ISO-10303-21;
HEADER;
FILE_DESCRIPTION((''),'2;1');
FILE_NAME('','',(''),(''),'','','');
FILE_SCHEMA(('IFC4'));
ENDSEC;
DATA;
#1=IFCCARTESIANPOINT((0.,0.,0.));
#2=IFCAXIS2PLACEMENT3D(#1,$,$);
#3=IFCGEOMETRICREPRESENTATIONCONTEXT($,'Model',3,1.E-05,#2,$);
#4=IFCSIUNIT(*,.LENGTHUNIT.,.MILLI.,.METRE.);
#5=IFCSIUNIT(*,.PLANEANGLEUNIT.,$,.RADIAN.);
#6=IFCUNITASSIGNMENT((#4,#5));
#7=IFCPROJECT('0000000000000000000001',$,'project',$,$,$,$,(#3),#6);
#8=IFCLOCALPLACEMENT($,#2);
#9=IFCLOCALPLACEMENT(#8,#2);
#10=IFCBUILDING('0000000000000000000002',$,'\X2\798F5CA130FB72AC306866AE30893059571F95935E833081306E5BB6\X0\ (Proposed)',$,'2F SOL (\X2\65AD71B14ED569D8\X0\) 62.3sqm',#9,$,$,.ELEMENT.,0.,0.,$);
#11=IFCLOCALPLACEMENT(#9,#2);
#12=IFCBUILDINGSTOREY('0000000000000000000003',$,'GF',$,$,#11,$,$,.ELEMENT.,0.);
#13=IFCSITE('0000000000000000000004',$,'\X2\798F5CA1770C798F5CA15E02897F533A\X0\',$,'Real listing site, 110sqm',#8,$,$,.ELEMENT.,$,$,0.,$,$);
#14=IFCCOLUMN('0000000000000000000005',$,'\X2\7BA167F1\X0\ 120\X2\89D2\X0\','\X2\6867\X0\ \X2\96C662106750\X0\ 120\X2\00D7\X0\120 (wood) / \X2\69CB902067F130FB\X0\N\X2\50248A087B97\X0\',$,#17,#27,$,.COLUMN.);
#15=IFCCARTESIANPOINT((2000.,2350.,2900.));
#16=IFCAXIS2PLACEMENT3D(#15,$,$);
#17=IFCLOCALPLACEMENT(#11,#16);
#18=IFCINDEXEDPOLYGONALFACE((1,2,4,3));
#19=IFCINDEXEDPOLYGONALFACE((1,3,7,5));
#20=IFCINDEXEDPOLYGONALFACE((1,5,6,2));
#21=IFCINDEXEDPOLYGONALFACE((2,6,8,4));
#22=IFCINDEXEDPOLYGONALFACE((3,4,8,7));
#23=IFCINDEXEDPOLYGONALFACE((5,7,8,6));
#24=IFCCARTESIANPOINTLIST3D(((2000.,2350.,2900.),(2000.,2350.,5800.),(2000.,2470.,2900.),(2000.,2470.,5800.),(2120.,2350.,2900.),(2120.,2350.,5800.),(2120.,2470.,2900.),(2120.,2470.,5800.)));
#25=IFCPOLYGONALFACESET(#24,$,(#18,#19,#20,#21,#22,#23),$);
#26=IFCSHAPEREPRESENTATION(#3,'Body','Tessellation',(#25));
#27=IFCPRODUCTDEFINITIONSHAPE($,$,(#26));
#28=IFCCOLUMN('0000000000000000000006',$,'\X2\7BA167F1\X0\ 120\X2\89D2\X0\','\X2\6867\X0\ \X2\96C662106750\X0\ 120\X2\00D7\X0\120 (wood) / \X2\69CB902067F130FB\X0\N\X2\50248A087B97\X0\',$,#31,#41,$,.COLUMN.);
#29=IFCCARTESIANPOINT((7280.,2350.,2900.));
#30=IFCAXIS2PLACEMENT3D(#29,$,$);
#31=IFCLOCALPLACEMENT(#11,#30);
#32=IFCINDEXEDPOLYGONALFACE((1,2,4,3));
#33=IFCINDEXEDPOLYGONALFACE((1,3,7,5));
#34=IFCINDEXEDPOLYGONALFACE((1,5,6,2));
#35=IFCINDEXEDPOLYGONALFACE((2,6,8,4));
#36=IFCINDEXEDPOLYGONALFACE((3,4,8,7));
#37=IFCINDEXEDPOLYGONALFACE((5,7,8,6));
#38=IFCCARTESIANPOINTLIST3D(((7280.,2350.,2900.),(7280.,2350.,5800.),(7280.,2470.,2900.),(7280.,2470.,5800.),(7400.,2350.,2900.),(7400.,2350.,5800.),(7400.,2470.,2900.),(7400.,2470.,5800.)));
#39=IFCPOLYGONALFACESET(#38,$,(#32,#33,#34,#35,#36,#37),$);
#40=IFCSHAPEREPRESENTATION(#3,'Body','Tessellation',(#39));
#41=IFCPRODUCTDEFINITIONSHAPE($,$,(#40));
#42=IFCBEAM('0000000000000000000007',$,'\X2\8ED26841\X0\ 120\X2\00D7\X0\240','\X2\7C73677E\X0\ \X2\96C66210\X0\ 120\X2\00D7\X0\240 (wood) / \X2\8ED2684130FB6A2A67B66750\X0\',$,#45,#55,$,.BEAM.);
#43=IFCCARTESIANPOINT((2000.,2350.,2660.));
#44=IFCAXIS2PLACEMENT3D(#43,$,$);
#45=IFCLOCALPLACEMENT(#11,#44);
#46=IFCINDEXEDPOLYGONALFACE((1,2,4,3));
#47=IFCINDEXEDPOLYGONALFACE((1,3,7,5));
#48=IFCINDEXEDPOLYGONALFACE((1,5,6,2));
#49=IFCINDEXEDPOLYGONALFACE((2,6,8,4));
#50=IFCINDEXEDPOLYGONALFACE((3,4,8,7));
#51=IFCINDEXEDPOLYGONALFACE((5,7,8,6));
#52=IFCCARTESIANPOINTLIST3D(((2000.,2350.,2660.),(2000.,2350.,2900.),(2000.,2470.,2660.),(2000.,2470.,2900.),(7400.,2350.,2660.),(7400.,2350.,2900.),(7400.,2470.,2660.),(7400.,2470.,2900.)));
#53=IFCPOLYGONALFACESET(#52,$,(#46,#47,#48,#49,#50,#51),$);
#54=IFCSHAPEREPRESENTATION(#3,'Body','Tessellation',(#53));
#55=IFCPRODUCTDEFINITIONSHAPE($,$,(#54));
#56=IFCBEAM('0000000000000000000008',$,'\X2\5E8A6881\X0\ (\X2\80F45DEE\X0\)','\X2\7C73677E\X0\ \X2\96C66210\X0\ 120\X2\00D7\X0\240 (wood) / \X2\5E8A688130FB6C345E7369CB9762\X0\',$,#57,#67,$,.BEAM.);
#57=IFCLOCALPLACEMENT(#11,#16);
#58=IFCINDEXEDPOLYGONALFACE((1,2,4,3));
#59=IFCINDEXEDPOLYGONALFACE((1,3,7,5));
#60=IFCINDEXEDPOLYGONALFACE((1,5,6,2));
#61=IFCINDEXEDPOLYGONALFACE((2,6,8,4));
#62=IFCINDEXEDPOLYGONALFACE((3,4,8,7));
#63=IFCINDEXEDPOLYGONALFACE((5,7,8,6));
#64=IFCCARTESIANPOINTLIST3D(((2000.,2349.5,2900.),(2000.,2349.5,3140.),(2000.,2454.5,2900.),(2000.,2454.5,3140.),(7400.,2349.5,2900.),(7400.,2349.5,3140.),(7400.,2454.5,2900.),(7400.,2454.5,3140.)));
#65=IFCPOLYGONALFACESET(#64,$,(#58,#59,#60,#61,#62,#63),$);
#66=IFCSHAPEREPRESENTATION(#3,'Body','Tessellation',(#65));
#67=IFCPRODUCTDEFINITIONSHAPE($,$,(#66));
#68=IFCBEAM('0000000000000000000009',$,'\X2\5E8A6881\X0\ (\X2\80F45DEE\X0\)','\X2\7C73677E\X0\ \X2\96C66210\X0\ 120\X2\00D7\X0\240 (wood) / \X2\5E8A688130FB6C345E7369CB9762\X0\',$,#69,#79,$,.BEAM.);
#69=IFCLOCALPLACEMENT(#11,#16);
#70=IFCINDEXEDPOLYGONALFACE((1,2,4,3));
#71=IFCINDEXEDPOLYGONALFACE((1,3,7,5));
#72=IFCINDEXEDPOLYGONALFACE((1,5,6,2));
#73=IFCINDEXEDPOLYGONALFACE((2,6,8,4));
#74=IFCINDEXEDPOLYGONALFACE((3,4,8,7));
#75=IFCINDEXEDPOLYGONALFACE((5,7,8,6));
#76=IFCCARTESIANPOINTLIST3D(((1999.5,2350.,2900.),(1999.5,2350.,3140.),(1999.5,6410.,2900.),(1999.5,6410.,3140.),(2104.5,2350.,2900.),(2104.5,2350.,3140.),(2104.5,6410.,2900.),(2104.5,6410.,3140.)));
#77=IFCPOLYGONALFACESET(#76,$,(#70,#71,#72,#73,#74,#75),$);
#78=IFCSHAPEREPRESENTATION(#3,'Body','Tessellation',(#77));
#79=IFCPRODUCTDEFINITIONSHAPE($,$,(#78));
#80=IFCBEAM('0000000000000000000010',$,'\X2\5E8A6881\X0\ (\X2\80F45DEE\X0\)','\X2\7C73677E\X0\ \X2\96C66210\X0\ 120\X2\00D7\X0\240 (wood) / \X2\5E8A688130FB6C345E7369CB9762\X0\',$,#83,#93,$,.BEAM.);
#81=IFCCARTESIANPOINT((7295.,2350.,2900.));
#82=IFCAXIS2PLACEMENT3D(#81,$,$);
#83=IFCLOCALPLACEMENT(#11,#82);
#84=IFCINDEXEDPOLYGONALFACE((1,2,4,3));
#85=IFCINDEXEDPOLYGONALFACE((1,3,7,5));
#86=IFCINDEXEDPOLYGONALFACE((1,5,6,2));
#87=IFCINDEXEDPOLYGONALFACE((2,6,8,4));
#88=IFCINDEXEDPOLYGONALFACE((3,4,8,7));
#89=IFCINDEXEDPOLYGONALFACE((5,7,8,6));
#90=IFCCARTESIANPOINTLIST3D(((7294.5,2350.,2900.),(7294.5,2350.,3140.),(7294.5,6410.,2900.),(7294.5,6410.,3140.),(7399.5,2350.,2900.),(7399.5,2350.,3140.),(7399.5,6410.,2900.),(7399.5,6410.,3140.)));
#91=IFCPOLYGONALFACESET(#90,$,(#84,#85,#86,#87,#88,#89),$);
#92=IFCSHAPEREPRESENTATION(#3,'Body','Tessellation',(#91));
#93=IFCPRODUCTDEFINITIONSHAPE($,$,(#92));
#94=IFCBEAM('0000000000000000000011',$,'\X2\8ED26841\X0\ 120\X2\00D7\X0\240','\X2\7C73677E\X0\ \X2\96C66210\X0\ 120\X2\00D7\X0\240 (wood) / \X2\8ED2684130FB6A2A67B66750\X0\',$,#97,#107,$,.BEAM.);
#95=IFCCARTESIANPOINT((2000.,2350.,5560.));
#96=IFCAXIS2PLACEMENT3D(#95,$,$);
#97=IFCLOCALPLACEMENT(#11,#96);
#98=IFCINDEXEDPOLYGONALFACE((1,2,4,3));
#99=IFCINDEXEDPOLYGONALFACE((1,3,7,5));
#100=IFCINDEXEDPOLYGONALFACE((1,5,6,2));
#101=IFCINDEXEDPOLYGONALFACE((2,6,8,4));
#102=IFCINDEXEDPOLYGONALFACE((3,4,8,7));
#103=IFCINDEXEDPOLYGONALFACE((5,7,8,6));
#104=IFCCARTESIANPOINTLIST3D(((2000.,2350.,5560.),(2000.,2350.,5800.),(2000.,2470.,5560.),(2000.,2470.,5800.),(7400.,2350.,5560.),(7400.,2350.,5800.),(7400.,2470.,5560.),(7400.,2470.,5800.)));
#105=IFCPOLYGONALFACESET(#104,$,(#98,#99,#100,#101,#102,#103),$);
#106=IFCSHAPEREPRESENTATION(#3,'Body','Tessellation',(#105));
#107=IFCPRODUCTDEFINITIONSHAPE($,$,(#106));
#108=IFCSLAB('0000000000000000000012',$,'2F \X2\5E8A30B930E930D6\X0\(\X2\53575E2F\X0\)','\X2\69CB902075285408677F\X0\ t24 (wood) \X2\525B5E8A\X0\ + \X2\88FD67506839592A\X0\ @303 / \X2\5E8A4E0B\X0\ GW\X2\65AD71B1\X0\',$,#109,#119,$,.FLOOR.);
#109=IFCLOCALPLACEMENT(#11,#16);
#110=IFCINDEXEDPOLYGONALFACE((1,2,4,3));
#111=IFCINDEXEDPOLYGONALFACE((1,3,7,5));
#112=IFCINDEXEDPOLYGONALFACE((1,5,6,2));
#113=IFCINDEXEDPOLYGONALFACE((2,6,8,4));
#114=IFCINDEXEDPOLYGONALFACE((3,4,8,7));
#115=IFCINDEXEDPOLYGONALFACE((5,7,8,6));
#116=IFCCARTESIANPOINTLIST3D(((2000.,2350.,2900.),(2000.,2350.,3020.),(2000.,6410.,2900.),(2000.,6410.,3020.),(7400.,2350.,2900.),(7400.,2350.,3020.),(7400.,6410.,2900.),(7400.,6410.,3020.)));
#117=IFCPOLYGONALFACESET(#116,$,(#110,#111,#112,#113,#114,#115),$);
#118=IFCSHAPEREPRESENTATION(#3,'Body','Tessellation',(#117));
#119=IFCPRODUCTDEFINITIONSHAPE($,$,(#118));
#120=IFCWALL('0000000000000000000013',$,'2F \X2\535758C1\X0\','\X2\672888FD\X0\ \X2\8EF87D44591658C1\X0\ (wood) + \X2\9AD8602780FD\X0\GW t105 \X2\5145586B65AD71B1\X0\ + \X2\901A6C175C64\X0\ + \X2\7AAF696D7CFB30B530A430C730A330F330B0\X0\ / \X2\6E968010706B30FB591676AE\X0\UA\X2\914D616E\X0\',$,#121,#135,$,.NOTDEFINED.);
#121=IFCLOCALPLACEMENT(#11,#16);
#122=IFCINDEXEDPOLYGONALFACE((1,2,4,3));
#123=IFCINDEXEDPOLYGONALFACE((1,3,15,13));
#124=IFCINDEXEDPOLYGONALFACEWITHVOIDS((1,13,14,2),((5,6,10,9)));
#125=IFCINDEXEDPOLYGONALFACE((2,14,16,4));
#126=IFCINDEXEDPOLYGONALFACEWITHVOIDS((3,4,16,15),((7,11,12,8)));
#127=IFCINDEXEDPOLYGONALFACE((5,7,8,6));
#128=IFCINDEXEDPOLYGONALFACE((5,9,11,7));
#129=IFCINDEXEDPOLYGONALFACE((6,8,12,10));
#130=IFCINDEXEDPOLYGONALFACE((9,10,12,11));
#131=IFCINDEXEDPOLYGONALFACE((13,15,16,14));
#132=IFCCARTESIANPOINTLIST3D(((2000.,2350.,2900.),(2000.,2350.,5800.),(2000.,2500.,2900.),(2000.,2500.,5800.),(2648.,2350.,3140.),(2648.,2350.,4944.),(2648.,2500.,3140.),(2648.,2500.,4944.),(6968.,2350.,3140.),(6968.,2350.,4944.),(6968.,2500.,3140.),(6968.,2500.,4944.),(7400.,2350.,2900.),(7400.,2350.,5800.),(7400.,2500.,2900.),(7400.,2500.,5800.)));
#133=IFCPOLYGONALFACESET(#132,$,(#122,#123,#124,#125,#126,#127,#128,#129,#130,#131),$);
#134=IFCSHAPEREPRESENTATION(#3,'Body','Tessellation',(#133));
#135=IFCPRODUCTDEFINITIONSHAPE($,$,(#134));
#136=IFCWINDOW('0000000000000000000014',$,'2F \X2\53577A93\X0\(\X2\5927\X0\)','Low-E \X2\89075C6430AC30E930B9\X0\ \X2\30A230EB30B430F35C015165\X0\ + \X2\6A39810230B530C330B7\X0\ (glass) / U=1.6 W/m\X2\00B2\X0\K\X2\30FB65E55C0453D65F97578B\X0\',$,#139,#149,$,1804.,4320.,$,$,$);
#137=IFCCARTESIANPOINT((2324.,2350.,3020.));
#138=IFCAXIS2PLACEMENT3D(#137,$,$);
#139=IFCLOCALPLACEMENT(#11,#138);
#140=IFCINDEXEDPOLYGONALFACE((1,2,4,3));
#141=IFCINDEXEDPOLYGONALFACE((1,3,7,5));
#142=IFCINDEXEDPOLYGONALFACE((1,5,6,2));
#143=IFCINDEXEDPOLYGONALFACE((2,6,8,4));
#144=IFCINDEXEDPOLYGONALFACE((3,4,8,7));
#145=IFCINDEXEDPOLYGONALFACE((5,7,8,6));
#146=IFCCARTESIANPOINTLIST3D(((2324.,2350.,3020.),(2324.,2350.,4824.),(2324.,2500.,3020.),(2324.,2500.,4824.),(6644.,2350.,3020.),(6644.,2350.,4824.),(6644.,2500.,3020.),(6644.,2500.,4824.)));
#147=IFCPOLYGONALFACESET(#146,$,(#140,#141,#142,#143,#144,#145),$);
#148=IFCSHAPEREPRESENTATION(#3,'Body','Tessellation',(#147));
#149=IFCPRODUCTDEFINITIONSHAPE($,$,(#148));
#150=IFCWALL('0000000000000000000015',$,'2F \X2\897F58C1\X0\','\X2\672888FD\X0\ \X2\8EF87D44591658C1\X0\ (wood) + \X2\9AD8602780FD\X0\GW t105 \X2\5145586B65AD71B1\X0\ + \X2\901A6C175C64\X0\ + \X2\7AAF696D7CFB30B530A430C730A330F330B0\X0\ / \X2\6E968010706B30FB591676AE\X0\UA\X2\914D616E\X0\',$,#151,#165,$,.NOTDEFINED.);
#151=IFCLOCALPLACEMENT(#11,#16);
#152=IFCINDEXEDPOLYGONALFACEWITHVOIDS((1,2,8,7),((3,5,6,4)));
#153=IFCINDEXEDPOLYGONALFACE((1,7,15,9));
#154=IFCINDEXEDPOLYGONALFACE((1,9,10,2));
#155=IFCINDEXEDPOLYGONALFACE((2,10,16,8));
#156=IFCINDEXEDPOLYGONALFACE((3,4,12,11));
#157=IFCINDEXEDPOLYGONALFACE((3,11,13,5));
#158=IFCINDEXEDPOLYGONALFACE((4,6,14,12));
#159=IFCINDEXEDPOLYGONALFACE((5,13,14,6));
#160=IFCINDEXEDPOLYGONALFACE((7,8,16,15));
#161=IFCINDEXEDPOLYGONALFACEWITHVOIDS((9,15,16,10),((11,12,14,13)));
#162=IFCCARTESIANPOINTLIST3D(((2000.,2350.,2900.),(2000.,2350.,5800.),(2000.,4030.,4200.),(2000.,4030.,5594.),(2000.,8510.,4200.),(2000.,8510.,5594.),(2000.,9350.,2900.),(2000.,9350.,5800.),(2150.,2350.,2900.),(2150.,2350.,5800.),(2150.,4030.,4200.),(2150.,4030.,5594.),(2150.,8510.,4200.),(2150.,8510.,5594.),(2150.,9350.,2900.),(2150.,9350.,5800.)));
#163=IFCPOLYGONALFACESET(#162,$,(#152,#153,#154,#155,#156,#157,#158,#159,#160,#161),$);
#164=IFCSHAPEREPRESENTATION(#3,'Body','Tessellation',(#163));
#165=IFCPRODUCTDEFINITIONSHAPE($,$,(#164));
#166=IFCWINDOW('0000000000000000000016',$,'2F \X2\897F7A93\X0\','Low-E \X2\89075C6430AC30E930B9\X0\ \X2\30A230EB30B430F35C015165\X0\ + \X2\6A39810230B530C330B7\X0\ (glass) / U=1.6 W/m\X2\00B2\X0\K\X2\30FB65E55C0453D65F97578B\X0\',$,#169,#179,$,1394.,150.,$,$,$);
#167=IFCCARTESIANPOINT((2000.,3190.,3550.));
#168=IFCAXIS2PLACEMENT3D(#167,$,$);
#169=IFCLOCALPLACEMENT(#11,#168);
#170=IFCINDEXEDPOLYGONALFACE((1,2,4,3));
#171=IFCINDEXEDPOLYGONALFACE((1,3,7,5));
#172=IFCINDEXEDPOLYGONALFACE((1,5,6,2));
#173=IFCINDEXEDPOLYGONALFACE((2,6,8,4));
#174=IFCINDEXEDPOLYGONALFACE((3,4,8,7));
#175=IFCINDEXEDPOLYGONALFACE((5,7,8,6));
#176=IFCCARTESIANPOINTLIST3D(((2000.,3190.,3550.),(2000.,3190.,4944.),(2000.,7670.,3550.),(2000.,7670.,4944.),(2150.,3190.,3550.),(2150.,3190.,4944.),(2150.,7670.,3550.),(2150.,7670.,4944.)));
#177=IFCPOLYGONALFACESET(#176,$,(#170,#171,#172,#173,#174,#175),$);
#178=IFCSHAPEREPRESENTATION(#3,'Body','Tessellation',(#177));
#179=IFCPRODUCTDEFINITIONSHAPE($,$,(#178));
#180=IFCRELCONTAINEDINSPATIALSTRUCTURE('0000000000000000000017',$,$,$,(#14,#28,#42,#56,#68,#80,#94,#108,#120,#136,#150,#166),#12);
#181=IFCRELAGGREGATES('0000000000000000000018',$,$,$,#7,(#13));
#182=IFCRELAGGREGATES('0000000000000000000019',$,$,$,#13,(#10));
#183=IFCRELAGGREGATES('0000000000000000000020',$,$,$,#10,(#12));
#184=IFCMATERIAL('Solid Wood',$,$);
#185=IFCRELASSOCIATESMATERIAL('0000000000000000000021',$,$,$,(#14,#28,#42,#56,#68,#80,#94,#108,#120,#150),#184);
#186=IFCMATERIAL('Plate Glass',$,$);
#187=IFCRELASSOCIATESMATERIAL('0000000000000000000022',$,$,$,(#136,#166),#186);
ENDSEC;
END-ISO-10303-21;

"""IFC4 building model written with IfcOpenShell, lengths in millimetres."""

from ifc_helpers import new_model, si_unit, frame, frame_2d, origin, place, context, project, spatial, rectangle, extrude, material, element, fill, save


model = new_model("IFC4")

# Units and contexts
model_context = context("Model", 3, precision=1e-05, world=origin())
ifc_project = project(units=[si_unit("LENGTHUNIT", "METRE", prefix="MILLI"), si_unit("PLANEANGLEUNIT", "RADIAN")], contexts=[model_context])

# Site, building, storey
site_placement = place(None, origin())
site = spatial("IfcSite", under=ifc_project, at=site_placement, Name="福岡県福岡市西区", ObjectType="Real listing site, 110sqm", CompositionType="ELEMENT", RefElevation=0.0)
building_placement = place(site_placement, origin())
building = spatial("IfcBuilding", under=site, at=building_placement, Name="福岡・犬と暮らす土間広めの家 (Proposed)", ObjectType="2F SOL (断熱仕様) 62.3sqm", CompositionType="ELEMENT", ElevationOfRefHeight=0.0, ElevationOfTerrain=0.0)
storey_placement = place(building_placement, origin())
storey = spatial("IfcBuildingStorey", under=building, at=storey_placement, Name="GF", CompositionType="ELEMENT", Elevation=0.0)

# Columns
ifc_material_1 = material(Name="Solid Wood")
column_1_placement = place(storey_placement, frame((2000.0, 2350.0, 2900.0)))
element("IfcColumn", 1, at=column_1_placement, inside=storey, material=ifc_material_1, Name="管柱 120角", Description="桧 集成材 120×120 (wood) / 構造柱・N値計算", PredefinedType="COLUMN", context=model_context, shape_type="SweptSolid", body=[
    extrude(rectangle(XDim=120.0, YDim=120.0, at=frame_2d((60.0, 60.0))), frame((2000.0, 2350.0, 2900.0)), (0.0, 0.0, 1.0), 2900.0),
])
column_2_placement = place(storey_placement, frame((7280.0, 2350.0, 2900.0)))
element("IfcColumn", 2, at=column_2_placement, inside=storey, material=ifc_material_1, Name="管柱 120角", Description="桧 集成材 120×120 (wood) / 構造柱・N値計算", PredefinedType="COLUMN", context=model_context, shape_type="SweptSolid", body=[
    extrude(rectangle(XDim=120.0, YDim=120.0, at=frame_2d((60.0, 60.0))), frame((7280.0, 2350.0, 2900.0)), (0.0, 0.0, 1.0), 2900.0),
])

# Beams
beam_1_placement = place(storey_placement, frame((2000.0, 2350.0, 2660.0)))
element("IfcBeam", 3, at=beam_1_placement, inside=storey, material=ifc_material_1, Name="軒桁 120×240", Description="米松 集成 120×240 (wood) / 軒桁・横架材", PredefinedType="BEAM", context=model_context, shape_type="SweptSolid", body=[
    extrude(rectangle(XDim=5400.0, YDim=120.0, at=frame_2d((2700.0, 60.0))), frame((2000.0, 2350.0, 2660.0)), (0.0, 0.0, 1.0), 240.0),
])
beam_2_placement = place(storey_placement, frame((2000.0, 2350.0, 2900.0)))
element("IfcBeam", 4, at=beam_2_placement, inside=storey, material=ifc_material_1, Name="床梁 (胴差)", Description="米松 集成 120×240 (wood) / 床梁・水平構面", PredefinedType="BEAM", context=model_context, shape_type="SweptSolid", body=[
    extrude(rectangle(XDim=5400.0, YDim=105.0, at=frame_2d((2700.0, 52.0))), frame((2000.0, 2350.0, 2900.0)), (0.0, 0.0, 1.0), 240.0),
])
beam_3_placement = place(storey_placement, frame((2000.0, 2350.0, 2900.0)))
element("IfcBeam", 5, at=beam_3_placement, inside=storey, material=ifc_material_1, Name="床梁 (胴差)", Description="米松 集成 120×240 (wood) / 床梁・水平構面", PredefinedType="BEAM", context=model_context, shape_type="SweptSolid", body=[
    extrude(rectangle(XDim=105.0, YDim=4060.0, at=frame_2d((52.0, 2030.0))), frame((2000.0, 2350.0, 2900.0)), (0.0, 0.0, 1.0), 240.0),
])
beam_4_placement = place(storey_placement, frame((7295.0, 2350.0, 2900.0)))
element("IfcBeam", 6, at=beam_4_placement, inside=storey, material=ifc_material_1, Name="床梁 (胴差)", Description="米松 集成 120×240 (wood) / 床梁・水平構面", PredefinedType="BEAM", context=model_context, shape_type="SweptSolid", body=[
    extrude(rectangle(XDim=105.0, YDim=4060.0, at=frame_2d((52.0, 2030.0))), frame((7295.0, 2350.0, 2900.0)), (0.0, 0.0, 1.0), 240.0),
])
beam_5_placement = place(storey_placement, frame((2000.0, 2350.0, 5560.0)))
element("IfcBeam", 7, at=beam_5_placement, inside=storey, material=ifc_material_1, Name="軒桁 120×240", Description="米松 集成 120×240 (wood) / 軒桁・横架材", PredefinedType="BEAM", context=model_context, shape_type="SweptSolid", body=[
    extrude(rectangle(XDim=5400.0, YDim=120.0, at=frame_2d((2700.0, 60.0))), frame((2000.0, 2350.0, 5560.0)), (0.0, 0.0, 1.0), 240.0),
])

# Slab
slab_placement = place(storey_placement, frame((2000.0, 2350.0, 2900.0)))
element("IfcSlab", 8, at=slab_placement, inside=storey, material=ifc_material_1, Name="2F 床スラブ(南帯)", Description="構造用合板 t24 (wood) 剛床 + 製材根太 @303 / 床下 GW断熱", PredefinedType="FLOOR", context=model_context, shape_type="SweptSolid", body=[
    extrude(rectangle(XDim=5400.0, YDim=4060.0, at=frame_2d((2700.0, 2030.0))), frame((2000.0, 2350.0, 2900.0)), (0.0, 0.0, 1.0), 120.0),
])

# Walls, openings, windows
wall_1_placement = place(storey_placement, frame((2000.0, 2350.0, 2900.0)))
wall_1 = element("IfcWall", 9, at=wall_1_placement, inside=storey, material=ifc_material_1, Name="2F 南壁", Description="木製 軸組外壁 (wood) + 高性能GW t105 充填断熱 + 通気層 + 窯業系サイディング / 準耐火・外皮UA配慮", PredefinedType="NOTDEFINED", context=model_context, shape_type="SweptSolid", body=[
    extrude(rectangle(XDim=5400.0, YDim=150.0, at=frame_2d((2700.0, 75.0))), frame((2000.0, 2350.0, 2900.0)), (0.0, 0.0, 1.0), 2900.0),
])
opening_1_placement = place(storey_placement, frame((2324.0, 2350.0, 3020.0)))
opening_1 = element("IfcOpeningElement", 10, at=opening_1_placement, cuts=wall_1, PredefinedType="NOTDEFINED", context=model_context, shape_type="SweptSolid", body=[
    extrude(rectangle(XDim=4320.0, YDim=150.0, at=frame_2d((2160.0, 75.0))), frame((2324.0, 2350.0, 3020.0)), (0.0, 0.0, 1.0), 1804.0),
])
ifc_material_2 = material(Name="Plate Glass")
window_1_placement = place(storey_placement, frame((2324.0, 2350.0, 3020.0)))
window_1 = element("IfcWindow", 11, at=window_1_placement, inside=storey, material=ifc_material_2, Name="2F 南窓(大)", Description="Low-E 複層ガラス アルゴン封入 + 樹脂サッシ (glass) / U=1.6 W/m²K・日射取得型", OverallHeight=1804.0, OverallWidth=4320.0, context=model_context, shape_type="SweptSolid", body=[
    extrude(rectangle(XDim=4320.0, YDim=150.0, at=frame_2d((2160.0, 75.0))), frame((2324.0, 2350.0, 3020.0)), (0.0, 0.0, 1.0), 1804.0),
])
fill(opening_1, window_1)
wall_2_placement = place(storey_placement, frame((2000.0, 2350.0, 2900.0)))
wall_2 = element("IfcWall", 12, at=wall_2_placement, inside=storey, material=ifc_material_1, Name="2F 西壁", Description="木製 軸組外壁 (wood) + 高性能GW t105 充填断熱 + 通気層 + 窯業系サイディング / 準耐火・外皮UA配慮", PredefinedType="NOTDEFINED", context=model_context, shape_type="SweptSolid", body=[
    extrude(rectangle(XDim=150.0, YDim=7000.0, at=frame_2d((75.0, 3500.0))), frame((2000.0, 2350.0, 2900.0)), (0.0, 0.0, 1.0), 2900.0),
])
opening_2_placement = place(storey_placement, frame((2000.0, 3190.0, 3550.0)))
opening_2 = element("IfcOpeningElement", 13, at=opening_2_placement, cuts=wall_2, PredefinedType="NOTDEFINED", context=model_context, shape_type="SweptSolid", body=[
    extrude(rectangle(XDim=150.0, YDim=4480.0, at=frame_2d((75.0, 2240.0))), frame((2000.0, 3190.0, 3550.0)), (0.0, 0.0, 1.0), 1394.0),
])
window_2_placement = place(storey_placement, frame((2000.0, 3190.0, 3550.0)))
window_2 = element("IfcWindow", 14, at=window_2_placement, inside=storey, material=ifc_material_2, Name="2F 西窓", Description="Low-E 複層ガラス アルゴン封入 + 樹脂サッシ (glass) / U=1.6 W/m²K・日射取得型", OverallHeight=1394.0, OverallWidth=150.0, context=model_context, shape_type="SweptSolid", body=[
    extrude(rectangle(XDim=150.0, YDim=4480.0, at=frame_2d((75.0, 2240.0))), frame((2000.0, 3190.0, 3550.0)), (0.0, 0.0, 1.0), 1394.0),
])
fill(opening_2, window_2)

save(model, "model.ifc")
